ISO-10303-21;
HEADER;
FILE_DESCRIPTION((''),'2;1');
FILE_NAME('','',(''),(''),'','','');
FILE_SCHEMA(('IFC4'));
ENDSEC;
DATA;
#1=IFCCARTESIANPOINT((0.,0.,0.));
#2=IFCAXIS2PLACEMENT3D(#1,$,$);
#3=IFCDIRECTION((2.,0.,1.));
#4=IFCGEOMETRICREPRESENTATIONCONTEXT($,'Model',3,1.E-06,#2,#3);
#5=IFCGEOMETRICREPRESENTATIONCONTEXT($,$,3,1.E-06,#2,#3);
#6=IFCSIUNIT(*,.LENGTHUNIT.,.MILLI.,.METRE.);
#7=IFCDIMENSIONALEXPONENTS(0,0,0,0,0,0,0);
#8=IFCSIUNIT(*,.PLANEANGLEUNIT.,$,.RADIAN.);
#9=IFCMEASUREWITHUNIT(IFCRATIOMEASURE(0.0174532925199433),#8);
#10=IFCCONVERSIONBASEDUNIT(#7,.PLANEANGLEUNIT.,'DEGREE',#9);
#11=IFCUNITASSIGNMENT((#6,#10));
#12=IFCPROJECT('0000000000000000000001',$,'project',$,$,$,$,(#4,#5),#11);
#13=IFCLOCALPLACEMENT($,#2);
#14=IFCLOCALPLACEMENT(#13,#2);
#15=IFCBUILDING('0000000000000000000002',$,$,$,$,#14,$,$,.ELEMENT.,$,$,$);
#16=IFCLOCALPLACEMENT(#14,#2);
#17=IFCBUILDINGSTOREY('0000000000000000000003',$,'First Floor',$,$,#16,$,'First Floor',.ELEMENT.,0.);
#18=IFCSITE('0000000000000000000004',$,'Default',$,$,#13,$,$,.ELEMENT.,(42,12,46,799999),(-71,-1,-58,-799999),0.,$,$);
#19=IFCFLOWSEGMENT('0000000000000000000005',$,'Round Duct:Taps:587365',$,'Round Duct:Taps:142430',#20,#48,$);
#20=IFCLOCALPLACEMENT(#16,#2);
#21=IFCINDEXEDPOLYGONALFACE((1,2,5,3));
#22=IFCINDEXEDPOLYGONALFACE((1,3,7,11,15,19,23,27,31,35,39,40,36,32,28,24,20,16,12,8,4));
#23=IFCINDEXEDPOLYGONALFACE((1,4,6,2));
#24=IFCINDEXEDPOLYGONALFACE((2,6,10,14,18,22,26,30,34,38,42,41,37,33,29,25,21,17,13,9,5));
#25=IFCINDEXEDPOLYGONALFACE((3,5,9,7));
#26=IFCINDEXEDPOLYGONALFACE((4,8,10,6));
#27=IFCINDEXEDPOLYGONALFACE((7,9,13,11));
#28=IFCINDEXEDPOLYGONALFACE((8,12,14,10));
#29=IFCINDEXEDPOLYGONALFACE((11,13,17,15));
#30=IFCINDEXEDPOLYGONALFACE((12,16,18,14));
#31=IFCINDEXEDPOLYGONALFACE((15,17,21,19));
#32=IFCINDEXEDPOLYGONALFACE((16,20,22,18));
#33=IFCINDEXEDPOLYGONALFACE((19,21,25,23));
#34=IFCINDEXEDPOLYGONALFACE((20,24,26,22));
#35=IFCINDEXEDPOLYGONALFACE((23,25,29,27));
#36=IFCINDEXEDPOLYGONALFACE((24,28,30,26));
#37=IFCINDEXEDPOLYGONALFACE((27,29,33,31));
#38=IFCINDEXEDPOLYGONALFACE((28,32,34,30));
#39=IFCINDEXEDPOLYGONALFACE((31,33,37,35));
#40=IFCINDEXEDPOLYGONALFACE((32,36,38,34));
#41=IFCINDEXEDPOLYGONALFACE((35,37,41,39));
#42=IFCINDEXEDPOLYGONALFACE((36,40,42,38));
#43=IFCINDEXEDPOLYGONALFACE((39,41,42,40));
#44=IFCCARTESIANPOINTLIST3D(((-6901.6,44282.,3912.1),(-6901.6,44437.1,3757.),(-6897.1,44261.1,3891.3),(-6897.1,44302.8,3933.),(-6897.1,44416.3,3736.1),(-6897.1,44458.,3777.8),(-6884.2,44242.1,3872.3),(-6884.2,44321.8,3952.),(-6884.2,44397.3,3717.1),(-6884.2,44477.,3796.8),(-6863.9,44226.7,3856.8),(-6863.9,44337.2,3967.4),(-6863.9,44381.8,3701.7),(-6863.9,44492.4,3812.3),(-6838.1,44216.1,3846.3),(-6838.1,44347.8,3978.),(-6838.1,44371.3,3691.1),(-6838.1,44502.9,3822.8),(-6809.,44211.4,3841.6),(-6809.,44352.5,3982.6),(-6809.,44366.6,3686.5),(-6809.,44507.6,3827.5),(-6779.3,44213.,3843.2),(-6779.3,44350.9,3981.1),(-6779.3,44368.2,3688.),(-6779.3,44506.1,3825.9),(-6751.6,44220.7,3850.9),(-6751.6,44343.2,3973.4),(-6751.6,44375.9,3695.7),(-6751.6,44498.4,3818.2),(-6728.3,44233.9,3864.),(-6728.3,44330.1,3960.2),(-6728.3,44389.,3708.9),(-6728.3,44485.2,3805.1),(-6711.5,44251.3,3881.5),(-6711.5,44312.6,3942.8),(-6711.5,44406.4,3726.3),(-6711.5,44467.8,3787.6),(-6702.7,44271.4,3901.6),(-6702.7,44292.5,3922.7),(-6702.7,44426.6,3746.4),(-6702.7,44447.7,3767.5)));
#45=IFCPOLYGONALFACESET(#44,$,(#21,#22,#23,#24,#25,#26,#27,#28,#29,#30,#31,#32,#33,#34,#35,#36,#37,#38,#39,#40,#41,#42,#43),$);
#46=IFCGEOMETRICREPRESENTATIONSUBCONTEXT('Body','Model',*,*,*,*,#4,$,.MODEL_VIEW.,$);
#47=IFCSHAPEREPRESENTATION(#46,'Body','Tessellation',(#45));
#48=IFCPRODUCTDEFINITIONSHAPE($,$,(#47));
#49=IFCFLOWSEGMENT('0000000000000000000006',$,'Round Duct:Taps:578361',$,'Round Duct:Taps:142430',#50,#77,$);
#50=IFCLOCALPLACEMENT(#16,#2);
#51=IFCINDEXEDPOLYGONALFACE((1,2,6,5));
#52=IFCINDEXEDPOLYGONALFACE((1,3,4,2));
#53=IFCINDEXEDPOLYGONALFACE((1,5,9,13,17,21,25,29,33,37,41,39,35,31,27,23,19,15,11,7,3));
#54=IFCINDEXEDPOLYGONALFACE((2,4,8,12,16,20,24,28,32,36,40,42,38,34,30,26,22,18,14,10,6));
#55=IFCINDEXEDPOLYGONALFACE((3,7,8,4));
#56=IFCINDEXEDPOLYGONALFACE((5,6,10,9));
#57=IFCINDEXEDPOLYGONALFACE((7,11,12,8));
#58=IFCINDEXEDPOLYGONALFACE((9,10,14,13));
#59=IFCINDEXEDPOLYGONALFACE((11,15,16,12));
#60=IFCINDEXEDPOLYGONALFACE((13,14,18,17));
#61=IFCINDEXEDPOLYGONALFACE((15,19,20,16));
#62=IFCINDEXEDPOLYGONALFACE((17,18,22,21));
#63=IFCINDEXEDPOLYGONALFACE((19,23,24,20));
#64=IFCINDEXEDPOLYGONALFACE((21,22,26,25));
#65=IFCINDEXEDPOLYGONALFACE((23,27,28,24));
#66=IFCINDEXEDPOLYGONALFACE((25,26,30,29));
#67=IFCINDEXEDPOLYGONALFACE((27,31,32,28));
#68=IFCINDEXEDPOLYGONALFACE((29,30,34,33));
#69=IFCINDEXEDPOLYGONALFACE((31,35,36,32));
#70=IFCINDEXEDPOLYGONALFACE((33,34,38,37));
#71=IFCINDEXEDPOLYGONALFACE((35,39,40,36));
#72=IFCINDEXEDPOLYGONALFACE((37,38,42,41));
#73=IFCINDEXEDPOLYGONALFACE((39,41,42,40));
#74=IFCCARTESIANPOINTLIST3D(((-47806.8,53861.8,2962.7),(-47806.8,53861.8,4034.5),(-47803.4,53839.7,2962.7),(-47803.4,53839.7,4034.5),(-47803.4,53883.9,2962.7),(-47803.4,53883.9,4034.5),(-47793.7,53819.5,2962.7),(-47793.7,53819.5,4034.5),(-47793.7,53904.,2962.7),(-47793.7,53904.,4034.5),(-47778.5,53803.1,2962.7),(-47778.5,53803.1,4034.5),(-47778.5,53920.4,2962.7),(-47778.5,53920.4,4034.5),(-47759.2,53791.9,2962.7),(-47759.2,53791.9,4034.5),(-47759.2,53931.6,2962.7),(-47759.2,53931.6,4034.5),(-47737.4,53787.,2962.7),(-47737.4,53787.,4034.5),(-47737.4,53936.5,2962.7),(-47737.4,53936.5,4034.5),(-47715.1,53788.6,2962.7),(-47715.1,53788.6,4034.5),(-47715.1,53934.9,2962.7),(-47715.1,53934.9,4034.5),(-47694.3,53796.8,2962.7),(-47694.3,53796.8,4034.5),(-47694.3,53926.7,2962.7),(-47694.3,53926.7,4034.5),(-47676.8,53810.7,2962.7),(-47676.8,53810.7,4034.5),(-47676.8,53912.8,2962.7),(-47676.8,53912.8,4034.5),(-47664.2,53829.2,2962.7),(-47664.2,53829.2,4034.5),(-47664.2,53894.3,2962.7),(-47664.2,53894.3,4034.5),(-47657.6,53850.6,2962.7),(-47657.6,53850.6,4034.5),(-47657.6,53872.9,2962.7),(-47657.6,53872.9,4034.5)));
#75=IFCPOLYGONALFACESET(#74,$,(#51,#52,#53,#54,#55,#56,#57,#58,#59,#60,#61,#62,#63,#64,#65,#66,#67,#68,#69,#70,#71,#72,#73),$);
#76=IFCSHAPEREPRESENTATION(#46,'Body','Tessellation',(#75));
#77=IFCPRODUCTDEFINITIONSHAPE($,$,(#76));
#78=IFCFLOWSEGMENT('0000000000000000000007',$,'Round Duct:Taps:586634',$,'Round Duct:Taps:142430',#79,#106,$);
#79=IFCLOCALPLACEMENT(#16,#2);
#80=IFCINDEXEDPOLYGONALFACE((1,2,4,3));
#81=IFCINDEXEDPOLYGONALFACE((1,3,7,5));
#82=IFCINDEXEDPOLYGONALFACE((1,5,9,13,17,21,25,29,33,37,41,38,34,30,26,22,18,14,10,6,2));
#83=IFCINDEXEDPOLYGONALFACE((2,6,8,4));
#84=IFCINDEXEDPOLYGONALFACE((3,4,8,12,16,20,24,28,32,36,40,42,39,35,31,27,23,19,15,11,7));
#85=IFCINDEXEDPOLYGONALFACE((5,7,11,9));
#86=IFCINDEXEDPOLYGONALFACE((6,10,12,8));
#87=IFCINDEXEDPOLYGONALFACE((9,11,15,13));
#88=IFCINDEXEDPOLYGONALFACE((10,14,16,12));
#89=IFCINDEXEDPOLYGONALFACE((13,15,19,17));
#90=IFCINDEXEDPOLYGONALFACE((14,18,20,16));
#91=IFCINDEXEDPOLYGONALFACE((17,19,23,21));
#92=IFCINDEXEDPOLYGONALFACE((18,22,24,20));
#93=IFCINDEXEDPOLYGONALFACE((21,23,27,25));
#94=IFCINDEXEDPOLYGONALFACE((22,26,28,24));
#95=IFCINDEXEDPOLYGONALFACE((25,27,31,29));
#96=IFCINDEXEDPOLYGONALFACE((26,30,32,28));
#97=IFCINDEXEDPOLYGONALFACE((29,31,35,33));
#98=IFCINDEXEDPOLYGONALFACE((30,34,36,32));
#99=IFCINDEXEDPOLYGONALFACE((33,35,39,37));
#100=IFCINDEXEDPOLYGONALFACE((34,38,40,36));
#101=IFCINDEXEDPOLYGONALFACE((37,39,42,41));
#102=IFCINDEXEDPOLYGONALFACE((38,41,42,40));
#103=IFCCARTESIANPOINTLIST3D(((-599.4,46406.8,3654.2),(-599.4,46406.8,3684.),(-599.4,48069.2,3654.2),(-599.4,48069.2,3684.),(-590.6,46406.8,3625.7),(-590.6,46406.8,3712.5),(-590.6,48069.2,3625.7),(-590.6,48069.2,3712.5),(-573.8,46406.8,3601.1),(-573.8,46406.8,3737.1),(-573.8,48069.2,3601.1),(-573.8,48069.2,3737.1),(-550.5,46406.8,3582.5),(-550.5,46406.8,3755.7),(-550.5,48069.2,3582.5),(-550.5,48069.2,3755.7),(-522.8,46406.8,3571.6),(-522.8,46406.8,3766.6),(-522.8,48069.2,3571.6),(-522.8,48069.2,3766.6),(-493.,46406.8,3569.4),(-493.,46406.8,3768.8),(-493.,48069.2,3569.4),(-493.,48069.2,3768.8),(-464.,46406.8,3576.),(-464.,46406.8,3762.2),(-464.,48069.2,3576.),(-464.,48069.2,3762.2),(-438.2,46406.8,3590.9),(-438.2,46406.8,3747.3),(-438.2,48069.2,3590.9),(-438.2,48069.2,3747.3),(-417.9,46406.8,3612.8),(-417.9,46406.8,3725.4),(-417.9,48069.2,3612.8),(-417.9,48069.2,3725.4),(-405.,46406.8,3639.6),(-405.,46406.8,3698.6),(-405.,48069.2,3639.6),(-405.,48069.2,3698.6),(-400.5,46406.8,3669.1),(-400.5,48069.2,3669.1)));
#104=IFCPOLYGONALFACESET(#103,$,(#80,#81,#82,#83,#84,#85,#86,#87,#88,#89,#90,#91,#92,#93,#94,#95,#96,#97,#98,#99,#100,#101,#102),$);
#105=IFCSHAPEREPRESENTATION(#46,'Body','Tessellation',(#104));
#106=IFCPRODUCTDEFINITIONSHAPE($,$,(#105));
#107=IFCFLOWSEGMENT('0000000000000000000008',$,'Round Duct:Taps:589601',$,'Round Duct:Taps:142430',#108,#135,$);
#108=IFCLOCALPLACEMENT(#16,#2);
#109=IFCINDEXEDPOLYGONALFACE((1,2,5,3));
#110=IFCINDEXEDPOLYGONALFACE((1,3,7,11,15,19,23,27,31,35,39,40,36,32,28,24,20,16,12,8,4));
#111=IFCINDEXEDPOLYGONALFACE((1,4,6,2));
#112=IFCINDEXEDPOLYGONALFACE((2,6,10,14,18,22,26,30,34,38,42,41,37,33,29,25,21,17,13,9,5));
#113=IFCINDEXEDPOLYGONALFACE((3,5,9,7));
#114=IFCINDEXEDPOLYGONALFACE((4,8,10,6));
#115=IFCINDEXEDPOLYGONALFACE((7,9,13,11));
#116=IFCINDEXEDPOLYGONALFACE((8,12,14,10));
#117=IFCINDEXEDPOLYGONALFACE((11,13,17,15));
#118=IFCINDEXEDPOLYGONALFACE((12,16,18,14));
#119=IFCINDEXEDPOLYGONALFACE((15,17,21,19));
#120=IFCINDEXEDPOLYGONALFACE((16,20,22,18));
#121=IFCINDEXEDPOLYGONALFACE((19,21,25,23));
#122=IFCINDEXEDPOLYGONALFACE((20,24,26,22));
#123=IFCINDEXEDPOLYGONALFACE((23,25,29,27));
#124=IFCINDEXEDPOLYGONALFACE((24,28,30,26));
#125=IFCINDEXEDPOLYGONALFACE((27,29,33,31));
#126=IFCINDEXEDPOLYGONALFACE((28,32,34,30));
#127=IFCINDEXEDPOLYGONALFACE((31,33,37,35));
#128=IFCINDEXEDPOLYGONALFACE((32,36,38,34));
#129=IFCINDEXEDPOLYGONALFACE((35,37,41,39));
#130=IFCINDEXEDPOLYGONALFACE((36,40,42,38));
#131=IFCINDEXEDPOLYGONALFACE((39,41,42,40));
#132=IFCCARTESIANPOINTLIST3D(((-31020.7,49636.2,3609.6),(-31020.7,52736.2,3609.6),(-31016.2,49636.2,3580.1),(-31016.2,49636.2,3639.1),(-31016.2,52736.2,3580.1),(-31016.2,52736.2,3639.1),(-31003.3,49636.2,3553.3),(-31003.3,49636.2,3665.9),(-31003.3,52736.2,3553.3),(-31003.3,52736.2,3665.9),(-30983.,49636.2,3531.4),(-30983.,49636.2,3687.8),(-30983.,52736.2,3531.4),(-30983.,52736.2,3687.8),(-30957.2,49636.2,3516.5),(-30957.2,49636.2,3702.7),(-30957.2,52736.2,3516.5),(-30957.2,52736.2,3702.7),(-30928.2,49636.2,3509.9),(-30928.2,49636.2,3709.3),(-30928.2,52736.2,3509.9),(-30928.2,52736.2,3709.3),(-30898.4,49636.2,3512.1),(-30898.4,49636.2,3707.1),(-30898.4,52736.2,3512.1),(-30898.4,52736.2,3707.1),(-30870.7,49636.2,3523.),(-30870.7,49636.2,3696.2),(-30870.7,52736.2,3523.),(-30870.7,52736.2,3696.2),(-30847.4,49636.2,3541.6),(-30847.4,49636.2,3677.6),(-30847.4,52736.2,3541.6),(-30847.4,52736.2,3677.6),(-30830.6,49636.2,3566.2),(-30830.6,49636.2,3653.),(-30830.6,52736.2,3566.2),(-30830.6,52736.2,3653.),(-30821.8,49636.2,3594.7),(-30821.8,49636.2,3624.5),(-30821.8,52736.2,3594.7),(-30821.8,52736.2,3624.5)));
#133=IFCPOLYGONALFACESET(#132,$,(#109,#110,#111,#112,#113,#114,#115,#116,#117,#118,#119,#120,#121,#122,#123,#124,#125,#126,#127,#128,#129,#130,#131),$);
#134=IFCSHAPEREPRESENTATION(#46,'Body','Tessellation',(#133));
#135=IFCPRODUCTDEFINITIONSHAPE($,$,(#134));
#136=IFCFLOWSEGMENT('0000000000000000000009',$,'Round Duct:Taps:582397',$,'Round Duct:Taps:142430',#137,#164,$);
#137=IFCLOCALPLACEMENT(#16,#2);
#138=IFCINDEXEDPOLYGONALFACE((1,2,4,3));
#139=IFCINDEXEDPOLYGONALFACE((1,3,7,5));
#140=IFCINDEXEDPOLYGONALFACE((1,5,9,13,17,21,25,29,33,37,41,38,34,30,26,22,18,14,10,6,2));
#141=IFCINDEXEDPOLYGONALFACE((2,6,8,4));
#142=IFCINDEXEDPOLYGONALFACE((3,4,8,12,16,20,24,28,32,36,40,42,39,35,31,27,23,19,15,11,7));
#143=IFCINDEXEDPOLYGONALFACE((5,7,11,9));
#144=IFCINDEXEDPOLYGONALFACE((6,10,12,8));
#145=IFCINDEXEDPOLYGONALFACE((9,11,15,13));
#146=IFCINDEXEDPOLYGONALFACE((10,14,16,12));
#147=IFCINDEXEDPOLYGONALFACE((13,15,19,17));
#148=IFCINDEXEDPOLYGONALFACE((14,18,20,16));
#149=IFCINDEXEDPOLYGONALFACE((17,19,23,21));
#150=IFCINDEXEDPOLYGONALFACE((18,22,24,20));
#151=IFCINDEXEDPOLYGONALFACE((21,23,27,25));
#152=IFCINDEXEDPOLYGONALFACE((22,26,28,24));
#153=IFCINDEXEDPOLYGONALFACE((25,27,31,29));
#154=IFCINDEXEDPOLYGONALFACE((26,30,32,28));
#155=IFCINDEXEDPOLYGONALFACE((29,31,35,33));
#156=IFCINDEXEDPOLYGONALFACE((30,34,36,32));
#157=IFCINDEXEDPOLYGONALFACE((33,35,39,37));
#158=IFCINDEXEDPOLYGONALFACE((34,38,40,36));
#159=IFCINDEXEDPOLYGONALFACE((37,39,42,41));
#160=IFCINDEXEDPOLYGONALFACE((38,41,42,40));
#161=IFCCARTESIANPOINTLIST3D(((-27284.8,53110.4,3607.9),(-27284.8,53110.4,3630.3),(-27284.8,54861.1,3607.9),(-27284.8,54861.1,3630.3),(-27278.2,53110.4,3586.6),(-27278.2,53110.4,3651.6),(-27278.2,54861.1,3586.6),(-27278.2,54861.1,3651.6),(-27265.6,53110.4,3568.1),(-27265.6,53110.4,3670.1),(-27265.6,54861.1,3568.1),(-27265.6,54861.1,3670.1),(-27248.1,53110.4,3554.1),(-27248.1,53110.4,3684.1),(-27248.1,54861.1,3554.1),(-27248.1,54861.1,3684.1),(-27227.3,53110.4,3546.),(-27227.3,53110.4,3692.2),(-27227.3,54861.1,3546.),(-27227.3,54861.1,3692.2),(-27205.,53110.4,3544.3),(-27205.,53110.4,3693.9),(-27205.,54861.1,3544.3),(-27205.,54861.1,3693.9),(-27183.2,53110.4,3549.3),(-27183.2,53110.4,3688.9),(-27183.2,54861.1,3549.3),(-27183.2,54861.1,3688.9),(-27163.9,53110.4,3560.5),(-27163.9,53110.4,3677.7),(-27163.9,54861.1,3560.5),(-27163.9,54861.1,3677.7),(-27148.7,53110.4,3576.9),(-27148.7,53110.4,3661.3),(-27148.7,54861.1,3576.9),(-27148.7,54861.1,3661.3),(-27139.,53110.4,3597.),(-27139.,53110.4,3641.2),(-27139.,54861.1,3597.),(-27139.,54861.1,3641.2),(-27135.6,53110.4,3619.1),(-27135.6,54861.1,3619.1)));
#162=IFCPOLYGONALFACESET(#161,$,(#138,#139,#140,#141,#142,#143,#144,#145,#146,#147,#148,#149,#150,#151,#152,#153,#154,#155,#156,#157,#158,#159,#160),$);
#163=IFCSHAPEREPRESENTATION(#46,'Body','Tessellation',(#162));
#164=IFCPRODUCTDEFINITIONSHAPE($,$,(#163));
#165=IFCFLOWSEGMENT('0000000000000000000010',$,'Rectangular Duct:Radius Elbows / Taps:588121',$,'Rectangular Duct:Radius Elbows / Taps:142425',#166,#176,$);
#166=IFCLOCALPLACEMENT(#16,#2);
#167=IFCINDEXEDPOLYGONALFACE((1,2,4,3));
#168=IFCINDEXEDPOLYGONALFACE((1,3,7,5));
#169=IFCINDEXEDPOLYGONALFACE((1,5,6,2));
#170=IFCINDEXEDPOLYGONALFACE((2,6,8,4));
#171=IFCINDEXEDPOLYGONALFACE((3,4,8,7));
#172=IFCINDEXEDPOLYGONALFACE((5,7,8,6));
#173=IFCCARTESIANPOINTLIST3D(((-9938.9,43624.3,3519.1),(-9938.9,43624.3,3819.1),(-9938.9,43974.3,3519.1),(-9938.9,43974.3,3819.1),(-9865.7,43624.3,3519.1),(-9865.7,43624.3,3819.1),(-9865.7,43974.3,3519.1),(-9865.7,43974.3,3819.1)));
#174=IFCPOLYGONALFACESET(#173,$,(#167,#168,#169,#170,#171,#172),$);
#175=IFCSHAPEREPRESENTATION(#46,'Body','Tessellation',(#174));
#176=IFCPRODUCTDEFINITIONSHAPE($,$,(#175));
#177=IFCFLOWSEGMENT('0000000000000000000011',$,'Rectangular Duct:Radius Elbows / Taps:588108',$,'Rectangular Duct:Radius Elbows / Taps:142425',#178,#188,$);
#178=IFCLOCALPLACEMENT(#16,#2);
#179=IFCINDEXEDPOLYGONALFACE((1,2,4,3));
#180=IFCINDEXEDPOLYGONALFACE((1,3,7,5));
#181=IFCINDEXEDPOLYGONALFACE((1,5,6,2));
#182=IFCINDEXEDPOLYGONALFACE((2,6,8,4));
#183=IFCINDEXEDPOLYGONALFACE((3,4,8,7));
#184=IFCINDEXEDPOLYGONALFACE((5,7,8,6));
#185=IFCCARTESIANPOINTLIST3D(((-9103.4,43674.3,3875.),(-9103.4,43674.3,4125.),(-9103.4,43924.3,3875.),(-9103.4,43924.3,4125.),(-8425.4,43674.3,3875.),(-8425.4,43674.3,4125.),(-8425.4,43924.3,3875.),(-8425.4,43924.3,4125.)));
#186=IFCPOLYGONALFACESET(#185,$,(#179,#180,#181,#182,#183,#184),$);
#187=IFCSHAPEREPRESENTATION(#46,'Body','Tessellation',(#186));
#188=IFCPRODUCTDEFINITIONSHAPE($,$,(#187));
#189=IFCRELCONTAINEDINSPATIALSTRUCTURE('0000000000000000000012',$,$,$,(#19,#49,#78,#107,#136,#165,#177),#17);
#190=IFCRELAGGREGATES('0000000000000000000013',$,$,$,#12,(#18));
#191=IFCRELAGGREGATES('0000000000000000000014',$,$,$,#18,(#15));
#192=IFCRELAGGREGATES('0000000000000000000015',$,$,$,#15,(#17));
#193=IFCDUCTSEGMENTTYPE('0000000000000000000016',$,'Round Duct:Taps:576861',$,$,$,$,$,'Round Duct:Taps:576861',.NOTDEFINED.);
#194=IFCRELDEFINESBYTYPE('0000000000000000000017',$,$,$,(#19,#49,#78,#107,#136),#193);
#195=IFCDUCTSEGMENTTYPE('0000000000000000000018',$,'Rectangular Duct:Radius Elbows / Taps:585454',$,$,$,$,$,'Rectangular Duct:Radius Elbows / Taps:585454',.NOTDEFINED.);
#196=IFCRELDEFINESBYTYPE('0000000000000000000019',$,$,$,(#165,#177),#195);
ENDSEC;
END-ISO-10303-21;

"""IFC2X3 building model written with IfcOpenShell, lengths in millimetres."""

from ifc_helpers import new_model, entity, si_unit, converted_unit, direction, frame, frame_2d, origin, origin_2d_with_axis, place, context, subcontext, project, spatial, rectangle, circle, extrude, type_object, element, save


model = new_model("IFC2X3")

# Units and contexts
model_context = context("Model", 3, precision=1e-06, world=origin(), true_north=direction((2.0, 0.0, 1.0)))
context_of_model = context(None, 3, precision=1e-06, world=origin(), true_north=direction((2.0, 0.0, 1.0)))
body_context = subcontext(model_context, "Body", "Model", "MODEL_VIEW")
ifc_project = project(units=[si_unit("LENGTHUNIT", "METRE", prefix="MILLI"), converted_unit("PLANEANGLEUNIT", "DEGREE", entity("IfcRatioMeasure", 0.0174532925199433), si_unit("PLANEANGLEUNIT", "RADIAN"), dimensions=[0, 0, 0, 0, 0, 0, 0])], contexts=[model_context, context_of_model])

# Site, building, storey
site_placement = place(None, origin())
site = spatial("IfcSite", under=ifc_project, at=site_placement, Name="Default", CompositionType="ELEMENT", RefLatitude=(42, 12, 46, 799999), RefLongitude=(-71, -1, -58, -799999), RefElevation=0.0)
building_placement = place(site_placement, origin())
building = spatial("IfcBuilding", under=site, at=building_placement, CompositionType="ELEMENT")
storey_placement = place(building_placement, origin())
storey = spatial("IfcBuildingStorey", under=building, at=storey_placement, Name="First Floor", LongName="First Floor", CompositionType="ELEMENT", Elevation=0.0)

# Flow segments
duct_segment_type_1 = type_object("IfcDuctSegmentType", Name="Round Duct:Taps:576861", ElementType="Round Duct:Taps:576861", PredefinedType="NOTDEFINED")
flow_segment_1_placement = place(storey_placement, origin())
element("IfcFlowSegment", 1, at=flow_segment_1_placement, inside=storey, type_object=duct_segment_type_1, Name="Round Duct:Taps:587365", ObjectType="Round Duct:Taps:142430", context=body_context, shape_type="SweptSolid", body=[
    extrude(circle(Radius=100.0, at=frame_2d((0.0, 0.0), x_axis=(1.0, 0.0))), frame((-6801.6, 44437.1, 3757.0), z_axis=(0.0, -0.707107, 0.707107), x_axis=(-1.0, 0.0, 0.0)), (0.0, 0.0, 1.0), 219.4),
])
flow_segment_2_placement = place(storey_placement, origin())
element("IfcFlowSegment", 2, at=flow_segment_2_placement, inside=storey, type_object=duct_segment_type_1, Name="Round Duct:Taps:578361", ObjectType="Round Duct:Taps:142430", context=body_context, shape_type="SweptSolid", body=[
    extrude(circle(Radius=75.0, at=origin_2d_with_axis()), frame((-47731.8, 53861.8, 2962.7), z_axis=(0.0, 0.0, 1.0), x_axis=(-1.0, 0.0, 0.0)), (0.0, 0.0, 1.0), 1071.8),
])
flow_segment_3_placement = place(storey_placement, origin())
element("IfcFlowSegment", 3, at=flow_segment_3_placement, inside=storey, type_object=duct_segment_type_1, Name="Round Duct:Taps:586634", ObjectType="Round Duct:Taps:142430", context=body_context, shape_type="SweptSolid", body=[
    extrude(circle(Radius=100.0, at=frame_2d((0.0, 0.0), x_axis=(1.0, 0.0))), frame((-500.5, 46406.8, 3669.1), z_axis=(0.0, 1.0, 0.0), x_axis=(1.0, 0.0, 0.0)), (0.0, 0.0, 1.0), 1662.4),
])
flow_segment_4_placement = place(storey_placement, origin())
element("IfcFlowSegment", 4, at=flow_segment_4_placement, inside=storey, type_object=duct_segment_type_1, Name="Round Duct:Taps:589601", ObjectType="Round Duct:Taps:142430", context=body_context, shape_type="SweptSolid", body=[
    extrude(circle(Radius=100.0, at=frame_2d((0.0, 0.0), x_axis=(1.0, 0.0))), frame((-30920.7, 49636.2, 3609.6), z_axis=(0.0, 1.0, 0.0), x_axis=(-1.0, 0.0, 0.0)), (0.0, 0.0, 1.0), 3100.0),
])
flow_segment_5_placement = place(storey_placement, origin())
element("IfcFlowSegment", 5, at=flow_segment_5_placement, inside=storey, type_object=duct_segment_type_1, Name="Round Duct:Taps:582397", ObjectType="Round Duct:Taps:142430", context=body_context, shape_type="SweptSolid", body=[
    extrude(circle(Radius=75.0, at=origin_2d_with_axis()), frame((-27210.6, 53110.4, 3619.1), z_axis=(0.0, 1.0, 0.0), x_axis=(1.0, 0.0, 0.0)), (0.0, 0.0, 1.0), 1750.7),
])
duct_segment_type_2 = type_object("IfcDuctSegmentType", Name="Rectangular Duct:Radius Elbows / Taps:585454", ElementType="Rectangular Duct:Radius Elbows / Taps:585454", PredefinedType="NOTDEFINED")
flow_segment_6_placement = place(storey_placement, origin())
element("IfcFlowSegment", 6, at=flow_segment_6_placement, inside=storey, type_object=duct_segment_type_2, Name="Rectangular Duct:Radius Elbows / Taps:588121", ObjectType="Rectangular Duct:Radius Elbows / Taps:142425", context=body_context, shape_type="SweptSolid", body=[
    extrude(rectangle(XDim=73.2, YDim=350.0, at=frame_2d((0.0, 0.0), x_axis=(1.0, 0.0))), frame((-9902.3, 43799.3, 3519.1)), (0.0, 0.0, 1.0), 300.0),
])
flow_segment_7_placement = place(storey_placement, origin())
element("IfcFlowSegment", 7, at=flow_segment_7_placement, inside=storey, type_object=duct_segment_type_2, Name="Rectangular Duct:Radius Elbows / Taps:588108", ObjectType="Rectangular Duct:Radius Elbows / Taps:142425", context=body_context, shape_type="SweptSolid", body=[
    extrude(rectangle(XDim=678.0, YDim=250.0, at=frame_2d((0.0, 0.0), x_axis=(1.0, 0.0))), frame((-8764.4, 43799.3, 3875.0)), (0.0, 0.0, 1.0), 250.0),
])

save(model, "model.ifc")
